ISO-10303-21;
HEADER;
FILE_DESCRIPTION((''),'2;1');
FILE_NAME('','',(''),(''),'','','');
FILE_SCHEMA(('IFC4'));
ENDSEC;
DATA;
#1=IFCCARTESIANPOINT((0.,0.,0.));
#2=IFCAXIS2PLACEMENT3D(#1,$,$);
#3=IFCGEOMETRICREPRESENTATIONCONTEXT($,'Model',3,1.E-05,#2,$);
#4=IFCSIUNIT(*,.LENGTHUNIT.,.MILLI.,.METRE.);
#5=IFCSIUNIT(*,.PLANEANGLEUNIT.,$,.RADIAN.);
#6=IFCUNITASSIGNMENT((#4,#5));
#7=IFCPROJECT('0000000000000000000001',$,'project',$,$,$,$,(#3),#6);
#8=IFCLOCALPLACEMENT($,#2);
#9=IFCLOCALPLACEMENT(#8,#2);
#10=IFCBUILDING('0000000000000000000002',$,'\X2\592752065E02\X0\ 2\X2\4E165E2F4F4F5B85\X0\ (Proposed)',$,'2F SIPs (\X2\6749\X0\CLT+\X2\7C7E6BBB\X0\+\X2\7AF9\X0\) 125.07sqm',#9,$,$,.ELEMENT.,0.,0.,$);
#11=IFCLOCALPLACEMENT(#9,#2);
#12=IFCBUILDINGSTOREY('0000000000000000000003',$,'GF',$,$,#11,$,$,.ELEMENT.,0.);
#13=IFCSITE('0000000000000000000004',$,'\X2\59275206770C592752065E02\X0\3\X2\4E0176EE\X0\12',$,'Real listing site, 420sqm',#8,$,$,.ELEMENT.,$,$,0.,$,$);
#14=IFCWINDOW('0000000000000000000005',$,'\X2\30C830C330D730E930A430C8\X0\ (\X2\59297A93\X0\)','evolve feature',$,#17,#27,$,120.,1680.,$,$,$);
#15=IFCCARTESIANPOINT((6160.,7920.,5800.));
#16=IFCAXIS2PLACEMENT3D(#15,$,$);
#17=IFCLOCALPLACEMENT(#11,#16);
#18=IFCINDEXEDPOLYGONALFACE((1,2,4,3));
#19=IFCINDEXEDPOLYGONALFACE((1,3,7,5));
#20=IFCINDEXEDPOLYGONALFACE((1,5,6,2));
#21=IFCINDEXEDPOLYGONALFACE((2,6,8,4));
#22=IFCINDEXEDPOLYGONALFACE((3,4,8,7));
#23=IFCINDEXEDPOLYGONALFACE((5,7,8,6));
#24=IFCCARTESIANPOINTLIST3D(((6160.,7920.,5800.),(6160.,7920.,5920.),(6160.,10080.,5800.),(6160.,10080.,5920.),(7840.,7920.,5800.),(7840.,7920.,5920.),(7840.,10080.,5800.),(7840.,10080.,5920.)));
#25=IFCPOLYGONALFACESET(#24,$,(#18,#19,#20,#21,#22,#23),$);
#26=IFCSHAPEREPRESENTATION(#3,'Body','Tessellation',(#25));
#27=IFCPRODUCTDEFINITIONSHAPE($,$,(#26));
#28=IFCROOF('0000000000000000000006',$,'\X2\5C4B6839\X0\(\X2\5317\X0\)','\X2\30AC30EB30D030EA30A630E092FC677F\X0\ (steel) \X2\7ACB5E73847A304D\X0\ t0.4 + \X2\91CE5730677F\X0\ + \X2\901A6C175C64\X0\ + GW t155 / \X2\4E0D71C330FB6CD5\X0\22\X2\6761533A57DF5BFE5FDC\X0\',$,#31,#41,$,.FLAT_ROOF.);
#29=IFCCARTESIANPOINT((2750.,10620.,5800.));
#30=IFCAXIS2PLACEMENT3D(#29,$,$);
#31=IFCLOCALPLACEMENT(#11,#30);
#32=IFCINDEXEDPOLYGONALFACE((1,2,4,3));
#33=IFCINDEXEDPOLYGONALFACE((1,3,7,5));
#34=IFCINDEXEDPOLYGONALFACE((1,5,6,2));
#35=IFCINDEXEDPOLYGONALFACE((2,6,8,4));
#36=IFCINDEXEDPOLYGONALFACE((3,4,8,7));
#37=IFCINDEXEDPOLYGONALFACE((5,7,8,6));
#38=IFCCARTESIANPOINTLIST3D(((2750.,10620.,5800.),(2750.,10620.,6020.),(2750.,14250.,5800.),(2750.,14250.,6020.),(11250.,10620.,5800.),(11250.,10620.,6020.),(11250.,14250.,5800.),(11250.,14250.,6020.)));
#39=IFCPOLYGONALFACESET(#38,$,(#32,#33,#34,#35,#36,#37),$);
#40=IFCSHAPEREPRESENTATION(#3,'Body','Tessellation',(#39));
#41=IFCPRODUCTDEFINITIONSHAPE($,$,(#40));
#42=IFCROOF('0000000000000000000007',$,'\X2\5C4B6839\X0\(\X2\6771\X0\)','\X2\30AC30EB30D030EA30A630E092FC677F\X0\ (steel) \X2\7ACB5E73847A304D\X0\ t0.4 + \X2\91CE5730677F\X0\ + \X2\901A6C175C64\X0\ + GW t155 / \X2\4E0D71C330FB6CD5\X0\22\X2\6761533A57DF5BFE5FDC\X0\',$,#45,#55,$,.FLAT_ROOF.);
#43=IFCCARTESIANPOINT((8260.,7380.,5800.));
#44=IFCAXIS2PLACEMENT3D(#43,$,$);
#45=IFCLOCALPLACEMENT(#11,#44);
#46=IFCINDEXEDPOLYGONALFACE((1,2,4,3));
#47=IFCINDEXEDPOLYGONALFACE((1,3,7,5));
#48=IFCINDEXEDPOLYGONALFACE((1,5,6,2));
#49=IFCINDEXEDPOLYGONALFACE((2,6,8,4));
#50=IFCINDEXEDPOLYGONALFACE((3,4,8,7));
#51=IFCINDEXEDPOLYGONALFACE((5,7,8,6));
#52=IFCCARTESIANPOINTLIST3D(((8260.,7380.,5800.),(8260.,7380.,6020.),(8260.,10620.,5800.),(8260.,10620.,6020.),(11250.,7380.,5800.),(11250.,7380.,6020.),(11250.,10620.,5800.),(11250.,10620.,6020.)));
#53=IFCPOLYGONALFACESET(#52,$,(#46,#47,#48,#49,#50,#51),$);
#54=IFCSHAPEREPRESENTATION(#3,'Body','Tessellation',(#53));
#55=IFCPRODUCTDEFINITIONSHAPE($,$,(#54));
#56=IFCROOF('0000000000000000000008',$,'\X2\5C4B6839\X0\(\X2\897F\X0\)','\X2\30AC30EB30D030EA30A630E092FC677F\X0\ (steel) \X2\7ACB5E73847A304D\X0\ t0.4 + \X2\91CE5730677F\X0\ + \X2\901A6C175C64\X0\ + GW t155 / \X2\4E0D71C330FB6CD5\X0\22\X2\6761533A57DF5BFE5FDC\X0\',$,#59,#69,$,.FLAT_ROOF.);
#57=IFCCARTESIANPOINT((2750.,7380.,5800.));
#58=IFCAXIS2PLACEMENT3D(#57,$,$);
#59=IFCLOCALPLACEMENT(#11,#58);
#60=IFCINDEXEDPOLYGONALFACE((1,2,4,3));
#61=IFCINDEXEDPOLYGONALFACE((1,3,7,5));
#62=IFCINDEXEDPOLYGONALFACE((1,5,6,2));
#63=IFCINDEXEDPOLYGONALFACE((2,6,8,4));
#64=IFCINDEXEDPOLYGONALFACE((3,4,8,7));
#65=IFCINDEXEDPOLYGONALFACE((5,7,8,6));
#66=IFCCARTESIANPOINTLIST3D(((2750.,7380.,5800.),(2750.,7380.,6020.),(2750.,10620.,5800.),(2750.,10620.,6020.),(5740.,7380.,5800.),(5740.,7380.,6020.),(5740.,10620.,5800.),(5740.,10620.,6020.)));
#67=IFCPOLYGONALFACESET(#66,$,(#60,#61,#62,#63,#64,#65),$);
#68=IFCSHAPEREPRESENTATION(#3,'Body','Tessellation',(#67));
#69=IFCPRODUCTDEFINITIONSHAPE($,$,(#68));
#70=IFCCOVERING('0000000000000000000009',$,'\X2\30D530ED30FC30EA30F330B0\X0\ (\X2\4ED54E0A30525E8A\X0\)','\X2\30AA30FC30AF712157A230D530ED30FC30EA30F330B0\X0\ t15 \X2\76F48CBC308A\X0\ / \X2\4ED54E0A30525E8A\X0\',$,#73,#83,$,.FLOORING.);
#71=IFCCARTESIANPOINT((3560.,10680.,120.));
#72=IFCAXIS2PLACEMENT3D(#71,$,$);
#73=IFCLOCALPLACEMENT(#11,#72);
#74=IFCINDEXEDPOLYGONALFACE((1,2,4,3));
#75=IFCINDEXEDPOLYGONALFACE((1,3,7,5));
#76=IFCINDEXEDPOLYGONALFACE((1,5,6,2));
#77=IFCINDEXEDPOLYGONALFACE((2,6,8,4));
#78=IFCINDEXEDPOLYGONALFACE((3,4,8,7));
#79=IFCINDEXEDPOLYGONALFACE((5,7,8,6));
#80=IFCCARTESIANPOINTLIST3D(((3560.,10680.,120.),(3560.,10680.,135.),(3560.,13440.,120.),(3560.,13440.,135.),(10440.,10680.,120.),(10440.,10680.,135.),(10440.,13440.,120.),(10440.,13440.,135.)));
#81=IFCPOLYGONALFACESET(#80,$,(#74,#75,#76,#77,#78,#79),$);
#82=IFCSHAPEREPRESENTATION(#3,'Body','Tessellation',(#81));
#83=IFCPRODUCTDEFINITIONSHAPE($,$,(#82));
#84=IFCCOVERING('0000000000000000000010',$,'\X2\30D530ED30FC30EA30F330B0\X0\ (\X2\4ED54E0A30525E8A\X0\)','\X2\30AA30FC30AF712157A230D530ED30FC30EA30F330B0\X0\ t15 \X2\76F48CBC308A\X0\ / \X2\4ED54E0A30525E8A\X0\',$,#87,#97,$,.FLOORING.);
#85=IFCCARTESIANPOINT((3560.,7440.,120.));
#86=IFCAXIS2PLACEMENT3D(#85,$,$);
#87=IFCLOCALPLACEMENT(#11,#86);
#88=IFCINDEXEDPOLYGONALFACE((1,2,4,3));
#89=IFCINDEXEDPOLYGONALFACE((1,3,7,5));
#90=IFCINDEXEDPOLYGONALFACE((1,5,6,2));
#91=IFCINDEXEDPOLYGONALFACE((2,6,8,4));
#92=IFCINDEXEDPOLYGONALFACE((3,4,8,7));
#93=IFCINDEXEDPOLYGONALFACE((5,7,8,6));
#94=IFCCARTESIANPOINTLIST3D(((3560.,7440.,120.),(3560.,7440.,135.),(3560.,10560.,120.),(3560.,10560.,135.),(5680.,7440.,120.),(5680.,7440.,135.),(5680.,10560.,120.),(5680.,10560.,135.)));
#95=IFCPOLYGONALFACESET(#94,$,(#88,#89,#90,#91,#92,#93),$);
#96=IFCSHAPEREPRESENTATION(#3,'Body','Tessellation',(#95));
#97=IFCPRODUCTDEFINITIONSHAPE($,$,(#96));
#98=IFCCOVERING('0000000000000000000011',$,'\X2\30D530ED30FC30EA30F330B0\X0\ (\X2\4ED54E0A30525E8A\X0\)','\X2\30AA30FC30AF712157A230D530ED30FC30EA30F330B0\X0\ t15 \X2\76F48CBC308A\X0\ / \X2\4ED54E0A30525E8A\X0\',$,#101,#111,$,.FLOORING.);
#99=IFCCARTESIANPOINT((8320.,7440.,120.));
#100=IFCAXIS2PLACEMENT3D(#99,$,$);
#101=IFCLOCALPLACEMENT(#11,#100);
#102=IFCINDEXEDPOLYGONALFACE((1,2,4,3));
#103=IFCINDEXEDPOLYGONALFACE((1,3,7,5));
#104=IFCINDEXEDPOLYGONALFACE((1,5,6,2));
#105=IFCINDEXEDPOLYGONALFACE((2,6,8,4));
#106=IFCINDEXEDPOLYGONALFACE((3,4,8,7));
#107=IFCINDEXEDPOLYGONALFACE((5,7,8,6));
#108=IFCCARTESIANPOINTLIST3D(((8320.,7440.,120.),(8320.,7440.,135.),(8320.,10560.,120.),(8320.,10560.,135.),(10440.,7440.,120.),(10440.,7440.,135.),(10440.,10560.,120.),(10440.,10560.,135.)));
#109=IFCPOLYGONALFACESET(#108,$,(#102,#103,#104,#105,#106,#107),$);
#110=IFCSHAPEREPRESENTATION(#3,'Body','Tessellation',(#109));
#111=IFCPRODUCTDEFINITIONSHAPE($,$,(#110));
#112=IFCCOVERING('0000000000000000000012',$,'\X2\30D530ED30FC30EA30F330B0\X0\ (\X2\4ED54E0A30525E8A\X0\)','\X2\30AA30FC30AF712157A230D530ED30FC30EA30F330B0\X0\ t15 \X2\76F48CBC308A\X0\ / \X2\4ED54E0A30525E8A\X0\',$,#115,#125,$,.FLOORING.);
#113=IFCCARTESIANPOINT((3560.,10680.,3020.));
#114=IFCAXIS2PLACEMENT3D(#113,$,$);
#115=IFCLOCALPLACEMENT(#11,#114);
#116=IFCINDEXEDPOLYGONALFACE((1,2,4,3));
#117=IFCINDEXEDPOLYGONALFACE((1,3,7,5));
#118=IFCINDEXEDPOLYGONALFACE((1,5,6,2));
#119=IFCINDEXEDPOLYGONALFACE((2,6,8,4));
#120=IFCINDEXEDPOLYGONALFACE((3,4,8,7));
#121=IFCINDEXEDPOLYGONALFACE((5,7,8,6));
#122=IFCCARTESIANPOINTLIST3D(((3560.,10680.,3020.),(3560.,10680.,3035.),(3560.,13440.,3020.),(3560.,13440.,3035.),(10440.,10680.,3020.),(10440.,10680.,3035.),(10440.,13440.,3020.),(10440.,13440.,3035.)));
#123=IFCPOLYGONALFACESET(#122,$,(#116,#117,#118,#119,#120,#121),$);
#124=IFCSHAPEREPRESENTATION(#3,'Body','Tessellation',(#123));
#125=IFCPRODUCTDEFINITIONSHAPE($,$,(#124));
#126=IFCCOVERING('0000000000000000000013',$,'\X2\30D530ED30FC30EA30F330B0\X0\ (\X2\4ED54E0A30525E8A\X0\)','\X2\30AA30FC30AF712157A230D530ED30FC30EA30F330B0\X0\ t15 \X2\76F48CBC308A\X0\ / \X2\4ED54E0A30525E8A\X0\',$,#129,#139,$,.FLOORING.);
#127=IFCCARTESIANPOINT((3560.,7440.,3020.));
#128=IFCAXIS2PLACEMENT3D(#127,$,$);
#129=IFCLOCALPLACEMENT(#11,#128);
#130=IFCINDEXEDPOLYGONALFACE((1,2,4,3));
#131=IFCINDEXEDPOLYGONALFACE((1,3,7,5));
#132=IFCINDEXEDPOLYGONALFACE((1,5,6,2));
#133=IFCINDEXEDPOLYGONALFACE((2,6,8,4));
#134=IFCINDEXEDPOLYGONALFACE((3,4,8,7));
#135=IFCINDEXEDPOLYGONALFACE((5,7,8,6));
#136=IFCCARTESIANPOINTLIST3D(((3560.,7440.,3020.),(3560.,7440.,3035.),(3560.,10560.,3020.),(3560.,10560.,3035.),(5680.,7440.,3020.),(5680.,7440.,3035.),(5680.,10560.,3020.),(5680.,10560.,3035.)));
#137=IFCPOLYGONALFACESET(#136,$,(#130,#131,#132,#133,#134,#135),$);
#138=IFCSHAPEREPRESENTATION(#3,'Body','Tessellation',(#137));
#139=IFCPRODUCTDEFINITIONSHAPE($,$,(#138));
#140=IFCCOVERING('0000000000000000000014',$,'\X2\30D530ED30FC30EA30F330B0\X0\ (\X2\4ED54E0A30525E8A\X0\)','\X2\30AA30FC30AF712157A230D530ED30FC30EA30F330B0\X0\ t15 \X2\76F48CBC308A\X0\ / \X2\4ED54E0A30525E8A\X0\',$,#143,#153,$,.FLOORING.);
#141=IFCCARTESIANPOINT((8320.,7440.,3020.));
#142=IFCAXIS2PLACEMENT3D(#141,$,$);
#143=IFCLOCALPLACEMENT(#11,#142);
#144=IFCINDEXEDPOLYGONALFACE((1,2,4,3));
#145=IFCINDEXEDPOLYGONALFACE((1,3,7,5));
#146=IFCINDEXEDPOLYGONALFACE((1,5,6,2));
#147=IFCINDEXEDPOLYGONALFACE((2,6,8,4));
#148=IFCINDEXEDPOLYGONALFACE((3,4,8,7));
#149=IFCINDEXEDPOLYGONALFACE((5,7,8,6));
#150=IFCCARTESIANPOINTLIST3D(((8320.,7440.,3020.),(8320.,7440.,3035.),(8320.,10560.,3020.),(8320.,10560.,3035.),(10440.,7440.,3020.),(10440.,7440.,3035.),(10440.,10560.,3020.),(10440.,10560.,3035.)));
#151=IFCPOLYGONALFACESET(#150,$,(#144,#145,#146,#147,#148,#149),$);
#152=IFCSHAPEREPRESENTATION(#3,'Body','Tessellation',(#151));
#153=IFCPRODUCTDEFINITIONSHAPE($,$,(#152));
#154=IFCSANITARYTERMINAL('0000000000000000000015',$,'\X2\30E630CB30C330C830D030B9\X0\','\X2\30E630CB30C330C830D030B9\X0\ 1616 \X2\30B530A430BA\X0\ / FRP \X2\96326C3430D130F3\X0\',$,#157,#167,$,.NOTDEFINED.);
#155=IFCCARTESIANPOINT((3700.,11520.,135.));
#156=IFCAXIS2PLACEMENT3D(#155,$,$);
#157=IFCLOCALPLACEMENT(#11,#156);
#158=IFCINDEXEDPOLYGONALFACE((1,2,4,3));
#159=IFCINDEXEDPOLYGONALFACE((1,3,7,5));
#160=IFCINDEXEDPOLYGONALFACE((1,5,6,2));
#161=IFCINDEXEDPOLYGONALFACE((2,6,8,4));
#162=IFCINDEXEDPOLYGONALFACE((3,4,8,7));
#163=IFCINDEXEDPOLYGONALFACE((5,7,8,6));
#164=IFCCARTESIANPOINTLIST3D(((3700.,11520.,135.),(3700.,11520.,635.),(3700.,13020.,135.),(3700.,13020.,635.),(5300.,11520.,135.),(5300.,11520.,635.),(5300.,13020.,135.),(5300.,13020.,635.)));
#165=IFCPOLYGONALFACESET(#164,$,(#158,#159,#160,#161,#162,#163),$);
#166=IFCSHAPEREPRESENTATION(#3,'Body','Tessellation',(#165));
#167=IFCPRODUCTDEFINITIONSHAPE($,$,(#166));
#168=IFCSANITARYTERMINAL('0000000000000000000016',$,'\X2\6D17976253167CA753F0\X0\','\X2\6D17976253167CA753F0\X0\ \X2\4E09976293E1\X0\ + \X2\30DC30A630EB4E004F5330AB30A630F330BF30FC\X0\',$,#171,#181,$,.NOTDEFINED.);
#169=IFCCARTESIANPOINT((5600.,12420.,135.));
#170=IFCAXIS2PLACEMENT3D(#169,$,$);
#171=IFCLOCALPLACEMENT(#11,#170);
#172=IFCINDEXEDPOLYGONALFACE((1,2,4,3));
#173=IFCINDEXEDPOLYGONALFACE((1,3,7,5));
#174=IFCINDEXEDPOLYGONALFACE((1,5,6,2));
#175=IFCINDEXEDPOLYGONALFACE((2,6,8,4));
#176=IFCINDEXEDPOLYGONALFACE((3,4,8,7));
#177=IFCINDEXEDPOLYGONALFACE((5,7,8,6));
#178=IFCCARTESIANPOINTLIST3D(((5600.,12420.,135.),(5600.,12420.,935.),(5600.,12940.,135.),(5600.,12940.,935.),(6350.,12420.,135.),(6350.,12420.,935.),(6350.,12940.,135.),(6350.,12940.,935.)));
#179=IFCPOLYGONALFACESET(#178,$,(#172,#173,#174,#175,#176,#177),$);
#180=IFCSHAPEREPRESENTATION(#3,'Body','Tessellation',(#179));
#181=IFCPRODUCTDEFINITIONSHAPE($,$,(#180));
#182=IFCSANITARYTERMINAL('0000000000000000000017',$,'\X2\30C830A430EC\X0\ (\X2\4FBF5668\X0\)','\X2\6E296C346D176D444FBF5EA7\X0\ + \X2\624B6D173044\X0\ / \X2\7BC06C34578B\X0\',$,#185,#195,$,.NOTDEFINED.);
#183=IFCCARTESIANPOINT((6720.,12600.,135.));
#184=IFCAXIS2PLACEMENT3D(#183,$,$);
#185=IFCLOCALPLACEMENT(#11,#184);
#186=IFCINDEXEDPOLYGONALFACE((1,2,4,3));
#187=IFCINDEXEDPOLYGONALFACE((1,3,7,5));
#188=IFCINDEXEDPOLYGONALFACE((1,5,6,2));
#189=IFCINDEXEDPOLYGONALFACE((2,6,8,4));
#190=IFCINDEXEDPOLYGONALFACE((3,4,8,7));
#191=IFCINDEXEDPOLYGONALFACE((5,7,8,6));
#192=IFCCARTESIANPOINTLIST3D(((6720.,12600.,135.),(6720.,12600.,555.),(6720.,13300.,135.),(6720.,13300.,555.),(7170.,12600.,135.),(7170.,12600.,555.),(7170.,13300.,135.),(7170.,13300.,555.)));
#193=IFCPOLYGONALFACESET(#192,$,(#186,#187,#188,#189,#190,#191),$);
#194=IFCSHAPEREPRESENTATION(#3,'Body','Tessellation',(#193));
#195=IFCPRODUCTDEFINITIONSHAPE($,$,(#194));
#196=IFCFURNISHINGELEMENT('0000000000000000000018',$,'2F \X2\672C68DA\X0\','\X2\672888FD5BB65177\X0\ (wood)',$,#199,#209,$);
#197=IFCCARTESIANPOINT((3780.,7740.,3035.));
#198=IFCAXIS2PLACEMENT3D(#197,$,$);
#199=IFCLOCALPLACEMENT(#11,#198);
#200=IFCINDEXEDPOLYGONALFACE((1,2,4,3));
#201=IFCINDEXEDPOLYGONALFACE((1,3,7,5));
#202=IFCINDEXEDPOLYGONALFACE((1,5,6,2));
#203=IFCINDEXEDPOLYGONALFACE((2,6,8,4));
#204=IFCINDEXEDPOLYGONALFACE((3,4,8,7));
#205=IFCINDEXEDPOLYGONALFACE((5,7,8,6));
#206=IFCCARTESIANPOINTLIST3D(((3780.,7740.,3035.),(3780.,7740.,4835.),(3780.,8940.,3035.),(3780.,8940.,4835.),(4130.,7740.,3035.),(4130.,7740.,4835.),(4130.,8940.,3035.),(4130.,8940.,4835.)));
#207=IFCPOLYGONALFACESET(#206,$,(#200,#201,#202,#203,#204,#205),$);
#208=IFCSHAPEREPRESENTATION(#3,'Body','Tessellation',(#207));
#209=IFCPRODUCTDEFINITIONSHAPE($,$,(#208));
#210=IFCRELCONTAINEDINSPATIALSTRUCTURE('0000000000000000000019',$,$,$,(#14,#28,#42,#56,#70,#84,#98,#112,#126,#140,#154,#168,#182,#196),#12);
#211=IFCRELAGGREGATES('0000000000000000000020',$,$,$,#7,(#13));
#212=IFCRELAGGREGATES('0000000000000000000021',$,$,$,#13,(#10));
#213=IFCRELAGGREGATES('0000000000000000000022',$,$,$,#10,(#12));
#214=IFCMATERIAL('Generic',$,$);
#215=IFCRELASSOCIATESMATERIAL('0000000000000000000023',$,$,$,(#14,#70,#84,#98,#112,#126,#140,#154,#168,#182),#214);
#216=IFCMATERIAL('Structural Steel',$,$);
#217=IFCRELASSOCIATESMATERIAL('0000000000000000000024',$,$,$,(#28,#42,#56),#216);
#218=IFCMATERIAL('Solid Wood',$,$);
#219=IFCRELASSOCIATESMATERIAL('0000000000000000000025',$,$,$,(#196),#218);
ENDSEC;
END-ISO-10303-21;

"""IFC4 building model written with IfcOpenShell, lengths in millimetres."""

from ifc_helpers import new_model, si_unit, frame, frame_2d, origin, place, context, project, spatial, rectangle, extrude, material, element, save


model = new_model("IFC4")

# Units and contexts
model_context = context("Model", 3, precision=1e-05, world=origin())
ifc_project = project(units=[si_unit("LENGTHUNIT", "METRE", prefix="MILLI"), si_unit("PLANEANGLEUNIT", "RADIAN")], contexts=[model_context])

# Site, building, storey
site_placement = place(None, origin())
site = spatial("IfcSite", under=ifc_project, at=site_placement, Name="大分県大分市3丁目12", ObjectType="Real listing site, 420sqm", CompositionType="ELEMENT", RefElevation=0.0)
building_placement = place(site_placement, origin())
building = spatial("IfcBuilding", under=site, at=building_placement, Name="大分市 2世帯住宅 (Proposed)", ObjectType="2F SIPs (杉CLT+籾殻+竹) 125.07sqm", CompositionType="ELEMENT", ElevationOfRefHeight=0.0, ElevationOfTerrain=0.0)
storey_placement = place(building_placement, origin())
storey = spatial("IfcBuildingStorey", under=building, at=storey_placement, Name="GF", CompositionType="ELEMENT", Elevation=0.0)

# Shared definitions
ifc_material_1 = material(Name="Solid Wood")

# Window
ifc_material_2 = material(Name="Generic")
window_1_placement = place(storey_placement, frame((6160.0, 7920.0, 5800.0)))
element("IfcWindow", 1, at=window_1_placement, inside=storey, material=ifc_material_2, Name="トップライト (天窓)", Description="evolve feature", OverallHeight=120.0, OverallWidth=1680.0, context=model_context, shape_type="SweptSolid", body=[
    extrude(rectangle(XDim=1680.0, YDim=2160.0, at=frame_2d((840.0, 1080.0))), frame((6160.0, 7920.0, 5800.0)), (0.0, 0.0, 1.0), 120.0),
])

# Roofs
ifc_material_3 = material(Name="Structural Steel")
roof_1_placement = place(storey_placement, frame((2750.0, 10620.0, 5800.0)))
element("IfcRoof", 2, at=roof_1_placement, inside=storey, material=ifc_material_3, Name="屋根(北)", Description="ガルバリウム鋼板 (steel) 立平葺き t0.4 + 野地板 + 通気層 + GW t155 / 不燃・法22条区域対応", PredefinedType="FLAT_ROOF", context=model_context, shape_type="SweptSolid", body=[
    extrude(rectangle(XDim=8500.0, YDim=3630.0, at=frame_2d((4250.0, 1815.0))), frame((2750.0, 10620.0, 5800.0)), (0.0, 0.0, 1.0), 220.0),
])
roof_2_placement = place(storey_placement, frame((8260.0, 7380.0, 5800.0)))
element("IfcRoof", 3, at=roof_2_placement, inside=storey, material=ifc_material_3, Name="屋根(東)", Description="ガルバリウム鋼板 (steel) 立平葺き t0.4 + 野地板 + 通気層 + GW t155 / 不燃・法22条区域対応", PredefinedType="FLAT_ROOF", context=model_context, shape_type="SweptSolid", body=[
    extrude(rectangle(XDim=2990.0, YDim=3240.0, at=frame_2d((1495.0, 1620.0))), frame((8260.0, 7380.0, 5800.0)), (0.0, 0.0, 1.0), 220.0),
])
roof_3_placement = place(storey_placement, frame((2750.0, 7380.0, 5800.0)))
element("IfcRoof", 4, at=roof_3_placement, inside=storey, material=ifc_material_3, Name="屋根(西)", Description="ガルバリウム鋼板 (steel) 立平葺き t0.4 + 野地板 + 通気層 + GW t155 / 不燃・法22条区域対応", PredefinedType="FLAT_ROOF", context=model_context, shape_type="SweptSolid", body=[
    extrude(rectangle(XDim=2990.0, YDim=3240.0, at=frame_2d((1495.0, 1620.0))), frame((2750.0, 7380.0, 5800.0)), (0.0, 0.0, 1.0), 220.0),
])

# Coverings
covering_1_placement = place(storey_placement, frame((3560.0, 10680.0, 120.0)))
element("IfcCovering", 5, at=covering_1_placement, inside=storey, material=ifc_material_2, Name="フローリング (仕上げ床)", Description="オーク無垢フローリング t15 直貼り / 仕上げ床", PredefinedType="FLOORING", context=model_context, shape_type="SweptSolid", body=[
    extrude(rectangle(XDim=6880.0, YDim=2760.0, at=frame_2d((3440.0, 1380.0))), frame((3560.0, 10680.0, 120.0)), (0.0, 0.0, 1.0), 15.0),
])
covering_2_placement = place(storey_placement, frame((3560.0, 7440.0, 120.0)))
element("IfcCovering", 6, at=covering_2_placement, inside=storey, material=ifc_material_2, Name="フローリング (仕上げ床)", Description="オーク無垢フローリング t15 直貼り / 仕上げ床", PredefinedType="FLOORING", context=model_context, shape_type="SweptSolid", body=[
    extrude(rectangle(XDim=2120.0, YDim=3120.0, at=frame_2d((1060.0, 1560.0))), frame((3560.0, 7440.0, 120.0)), (0.0, 0.0, 1.0), 15.0),
])
covering_3_placement = place(storey_placement, frame((8320.0, 7440.0, 120.0)))
element("IfcCovering", 7, at=covering_3_placement, inside=storey, material=ifc_material_2, Name="フローリング (仕上げ床)", Description="オーク無垢フローリング t15 直貼り / 仕上げ床", PredefinedType="FLOORING", context=model_context, shape_type="SweptSolid", body=[
    extrude(rectangle(XDim=2120.0, YDim=3120.0, at=frame_2d((1060.0, 1560.0))), frame((8320.0, 7440.0, 120.0)), (0.0, 0.0, 1.0), 15.0),
])
covering_4_placement = place(storey_placement, frame((3560.0, 10680.0, 3020.0)))
element("IfcCovering", 8, at=covering_4_placement, inside=storey, material=ifc_material_2, Name="フローリング (仕上げ床)", Description="オーク無垢フローリング t15 直貼り / 仕上げ床", PredefinedType="FLOORING", context=model_context, shape_type="SweptSolid", body=[
    extrude(rectangle(XDim=6880.0, YDim=2760.0, at=frame_2d((3440.0, 1380.0))), frame((3560.0, 10680.0, 3020.0)), (0.0, 0.0, 1.0), 15.0),
])
covering_5_placement = place(storey_placement, frame((3560.0, 7440.0, 3020.0)))
element("IfcCovering", 9, at=covering_5_placement, inside=storey, material=ifc_material_2, Name="フローリング (仕上げ床)", Description="オーク無垢フローリング t15 直貼り / 仕上げ床", PredefinedType="FLOORING", context=model_context, shape_type="SweptSolid", body=[
    extrude(rectangle(XDim=2120.0, YDim=3120.0, at=frame_2d((1060.0, 1560.0))), frame((3560.0, 7440.0, 3020.0)), (0.0, 0.0, 1.0), 15.0),
])
covering_6_placement = place(storey_placement, frame((8320.0, 7440.0, 3020.0)))
element("IfcCovering", 10, at=covering_6_placement, inside=storey, material=ifc_material_2, Name="フローリング (仕上げ床)", Description="オーク無垢フローリング t15 直貼り / 仕上げ床", PredefinedType="FLOORING", context=model_context, shape_type="SweptSolid", body=[
    extrude(rectangle(XDim=2120.0, YDim=3120.0, at=frame_2d((1060.0, 1560.0))), frame((8320.0, 7440.0, 3020.0)), (0.0, 0.0, 1.0), 15.0),
])

# Sanitary terminals
sanitary_terminal_1_placement = place(storey_placement, frame((3700.0, 11520.0, 135.0)))
element("IfcSanitaryTerminal", 11, at=sanitary_terminal_1_placement, inside=storey, material=ifc_material_2, Name="ユニットバス", Description="ユニットバス 1616 サイズ / FRP 防水パン", PredefinedType="NOTDEFINED", context=model_context, shape_type="SweptSolid", body=[
    extrude(rectangle(XDim=1600.0, YDim=1500.0, at=frame_2d((800.0, 750.0))), frame((3700.0, 11520.0, 135.0)), (0.0, 0.0, 1.0), 500.0),
])
sanitary_terminal_2_placement = place(storey_placement, frame((5600.0, 12420.0, 135.0)))
element("IfcSanitaryTerminal", 12, at=sanitary_terminal_2_placement, inside=storey, material=ifc_material_2, Name="洗面化粧台", Description="洗面化粧台 三面鏡 + ボウル一体カウンター", PredefinedType="NOTDEFINED", context=model_context, shape_type="SweptSolid", body=[
    extrude(rectangle(XDim=750.0, YDim=520.0, at=frame_2d((375.0, 260.0))), frame((5600.0, 12420.0, 135.0)), (0.0, 0.0, 1.0), 800.0),
])
sanitary_terminal_3_placement = place(storey_placement, frame((6720.0, 12600.0, 135.0)))
element("IfcSanitaryTerminal", 13, at=sanitary_terminal_3_placement, inside=storey, material=ifc_material_2, Name="トイレ (便器)", Description="温水洗浄便座 + 手洗い / 節水型", PredefinedType="NOTDEFINED", context=model_context, shape_type="SweptSolid", body=[
    extrude(rectangle(XDim=450.0, YDim=700.0, at=frame_2d((225.0, 350.0))), frame((6720.0, 12600.0, 135.0)), (0.0, 0.0, 1.0), 420.0),
])

# Furnishing element
furnishing_placement = place(storey_placement, frame((3780.0, 7740.0, 3035.0)))
element("IfcFurnishingElement", 14, at=furnishing_placement, inside=storey, material=ifc_material_1, Name="2F 本棚", Description="木製家具 (wood)", context=model_context, shape_type="SweptSolid", body=[
    extrude(rectangle(XDim=350.0, YDim=1200.0, at=frame_2d((175.0, 600.0))), frame((3780.0, 7740.0, 3035.0)), (0.0, 0.0, 1.0), 1800.0),
])

save(model, "model.ifc")
